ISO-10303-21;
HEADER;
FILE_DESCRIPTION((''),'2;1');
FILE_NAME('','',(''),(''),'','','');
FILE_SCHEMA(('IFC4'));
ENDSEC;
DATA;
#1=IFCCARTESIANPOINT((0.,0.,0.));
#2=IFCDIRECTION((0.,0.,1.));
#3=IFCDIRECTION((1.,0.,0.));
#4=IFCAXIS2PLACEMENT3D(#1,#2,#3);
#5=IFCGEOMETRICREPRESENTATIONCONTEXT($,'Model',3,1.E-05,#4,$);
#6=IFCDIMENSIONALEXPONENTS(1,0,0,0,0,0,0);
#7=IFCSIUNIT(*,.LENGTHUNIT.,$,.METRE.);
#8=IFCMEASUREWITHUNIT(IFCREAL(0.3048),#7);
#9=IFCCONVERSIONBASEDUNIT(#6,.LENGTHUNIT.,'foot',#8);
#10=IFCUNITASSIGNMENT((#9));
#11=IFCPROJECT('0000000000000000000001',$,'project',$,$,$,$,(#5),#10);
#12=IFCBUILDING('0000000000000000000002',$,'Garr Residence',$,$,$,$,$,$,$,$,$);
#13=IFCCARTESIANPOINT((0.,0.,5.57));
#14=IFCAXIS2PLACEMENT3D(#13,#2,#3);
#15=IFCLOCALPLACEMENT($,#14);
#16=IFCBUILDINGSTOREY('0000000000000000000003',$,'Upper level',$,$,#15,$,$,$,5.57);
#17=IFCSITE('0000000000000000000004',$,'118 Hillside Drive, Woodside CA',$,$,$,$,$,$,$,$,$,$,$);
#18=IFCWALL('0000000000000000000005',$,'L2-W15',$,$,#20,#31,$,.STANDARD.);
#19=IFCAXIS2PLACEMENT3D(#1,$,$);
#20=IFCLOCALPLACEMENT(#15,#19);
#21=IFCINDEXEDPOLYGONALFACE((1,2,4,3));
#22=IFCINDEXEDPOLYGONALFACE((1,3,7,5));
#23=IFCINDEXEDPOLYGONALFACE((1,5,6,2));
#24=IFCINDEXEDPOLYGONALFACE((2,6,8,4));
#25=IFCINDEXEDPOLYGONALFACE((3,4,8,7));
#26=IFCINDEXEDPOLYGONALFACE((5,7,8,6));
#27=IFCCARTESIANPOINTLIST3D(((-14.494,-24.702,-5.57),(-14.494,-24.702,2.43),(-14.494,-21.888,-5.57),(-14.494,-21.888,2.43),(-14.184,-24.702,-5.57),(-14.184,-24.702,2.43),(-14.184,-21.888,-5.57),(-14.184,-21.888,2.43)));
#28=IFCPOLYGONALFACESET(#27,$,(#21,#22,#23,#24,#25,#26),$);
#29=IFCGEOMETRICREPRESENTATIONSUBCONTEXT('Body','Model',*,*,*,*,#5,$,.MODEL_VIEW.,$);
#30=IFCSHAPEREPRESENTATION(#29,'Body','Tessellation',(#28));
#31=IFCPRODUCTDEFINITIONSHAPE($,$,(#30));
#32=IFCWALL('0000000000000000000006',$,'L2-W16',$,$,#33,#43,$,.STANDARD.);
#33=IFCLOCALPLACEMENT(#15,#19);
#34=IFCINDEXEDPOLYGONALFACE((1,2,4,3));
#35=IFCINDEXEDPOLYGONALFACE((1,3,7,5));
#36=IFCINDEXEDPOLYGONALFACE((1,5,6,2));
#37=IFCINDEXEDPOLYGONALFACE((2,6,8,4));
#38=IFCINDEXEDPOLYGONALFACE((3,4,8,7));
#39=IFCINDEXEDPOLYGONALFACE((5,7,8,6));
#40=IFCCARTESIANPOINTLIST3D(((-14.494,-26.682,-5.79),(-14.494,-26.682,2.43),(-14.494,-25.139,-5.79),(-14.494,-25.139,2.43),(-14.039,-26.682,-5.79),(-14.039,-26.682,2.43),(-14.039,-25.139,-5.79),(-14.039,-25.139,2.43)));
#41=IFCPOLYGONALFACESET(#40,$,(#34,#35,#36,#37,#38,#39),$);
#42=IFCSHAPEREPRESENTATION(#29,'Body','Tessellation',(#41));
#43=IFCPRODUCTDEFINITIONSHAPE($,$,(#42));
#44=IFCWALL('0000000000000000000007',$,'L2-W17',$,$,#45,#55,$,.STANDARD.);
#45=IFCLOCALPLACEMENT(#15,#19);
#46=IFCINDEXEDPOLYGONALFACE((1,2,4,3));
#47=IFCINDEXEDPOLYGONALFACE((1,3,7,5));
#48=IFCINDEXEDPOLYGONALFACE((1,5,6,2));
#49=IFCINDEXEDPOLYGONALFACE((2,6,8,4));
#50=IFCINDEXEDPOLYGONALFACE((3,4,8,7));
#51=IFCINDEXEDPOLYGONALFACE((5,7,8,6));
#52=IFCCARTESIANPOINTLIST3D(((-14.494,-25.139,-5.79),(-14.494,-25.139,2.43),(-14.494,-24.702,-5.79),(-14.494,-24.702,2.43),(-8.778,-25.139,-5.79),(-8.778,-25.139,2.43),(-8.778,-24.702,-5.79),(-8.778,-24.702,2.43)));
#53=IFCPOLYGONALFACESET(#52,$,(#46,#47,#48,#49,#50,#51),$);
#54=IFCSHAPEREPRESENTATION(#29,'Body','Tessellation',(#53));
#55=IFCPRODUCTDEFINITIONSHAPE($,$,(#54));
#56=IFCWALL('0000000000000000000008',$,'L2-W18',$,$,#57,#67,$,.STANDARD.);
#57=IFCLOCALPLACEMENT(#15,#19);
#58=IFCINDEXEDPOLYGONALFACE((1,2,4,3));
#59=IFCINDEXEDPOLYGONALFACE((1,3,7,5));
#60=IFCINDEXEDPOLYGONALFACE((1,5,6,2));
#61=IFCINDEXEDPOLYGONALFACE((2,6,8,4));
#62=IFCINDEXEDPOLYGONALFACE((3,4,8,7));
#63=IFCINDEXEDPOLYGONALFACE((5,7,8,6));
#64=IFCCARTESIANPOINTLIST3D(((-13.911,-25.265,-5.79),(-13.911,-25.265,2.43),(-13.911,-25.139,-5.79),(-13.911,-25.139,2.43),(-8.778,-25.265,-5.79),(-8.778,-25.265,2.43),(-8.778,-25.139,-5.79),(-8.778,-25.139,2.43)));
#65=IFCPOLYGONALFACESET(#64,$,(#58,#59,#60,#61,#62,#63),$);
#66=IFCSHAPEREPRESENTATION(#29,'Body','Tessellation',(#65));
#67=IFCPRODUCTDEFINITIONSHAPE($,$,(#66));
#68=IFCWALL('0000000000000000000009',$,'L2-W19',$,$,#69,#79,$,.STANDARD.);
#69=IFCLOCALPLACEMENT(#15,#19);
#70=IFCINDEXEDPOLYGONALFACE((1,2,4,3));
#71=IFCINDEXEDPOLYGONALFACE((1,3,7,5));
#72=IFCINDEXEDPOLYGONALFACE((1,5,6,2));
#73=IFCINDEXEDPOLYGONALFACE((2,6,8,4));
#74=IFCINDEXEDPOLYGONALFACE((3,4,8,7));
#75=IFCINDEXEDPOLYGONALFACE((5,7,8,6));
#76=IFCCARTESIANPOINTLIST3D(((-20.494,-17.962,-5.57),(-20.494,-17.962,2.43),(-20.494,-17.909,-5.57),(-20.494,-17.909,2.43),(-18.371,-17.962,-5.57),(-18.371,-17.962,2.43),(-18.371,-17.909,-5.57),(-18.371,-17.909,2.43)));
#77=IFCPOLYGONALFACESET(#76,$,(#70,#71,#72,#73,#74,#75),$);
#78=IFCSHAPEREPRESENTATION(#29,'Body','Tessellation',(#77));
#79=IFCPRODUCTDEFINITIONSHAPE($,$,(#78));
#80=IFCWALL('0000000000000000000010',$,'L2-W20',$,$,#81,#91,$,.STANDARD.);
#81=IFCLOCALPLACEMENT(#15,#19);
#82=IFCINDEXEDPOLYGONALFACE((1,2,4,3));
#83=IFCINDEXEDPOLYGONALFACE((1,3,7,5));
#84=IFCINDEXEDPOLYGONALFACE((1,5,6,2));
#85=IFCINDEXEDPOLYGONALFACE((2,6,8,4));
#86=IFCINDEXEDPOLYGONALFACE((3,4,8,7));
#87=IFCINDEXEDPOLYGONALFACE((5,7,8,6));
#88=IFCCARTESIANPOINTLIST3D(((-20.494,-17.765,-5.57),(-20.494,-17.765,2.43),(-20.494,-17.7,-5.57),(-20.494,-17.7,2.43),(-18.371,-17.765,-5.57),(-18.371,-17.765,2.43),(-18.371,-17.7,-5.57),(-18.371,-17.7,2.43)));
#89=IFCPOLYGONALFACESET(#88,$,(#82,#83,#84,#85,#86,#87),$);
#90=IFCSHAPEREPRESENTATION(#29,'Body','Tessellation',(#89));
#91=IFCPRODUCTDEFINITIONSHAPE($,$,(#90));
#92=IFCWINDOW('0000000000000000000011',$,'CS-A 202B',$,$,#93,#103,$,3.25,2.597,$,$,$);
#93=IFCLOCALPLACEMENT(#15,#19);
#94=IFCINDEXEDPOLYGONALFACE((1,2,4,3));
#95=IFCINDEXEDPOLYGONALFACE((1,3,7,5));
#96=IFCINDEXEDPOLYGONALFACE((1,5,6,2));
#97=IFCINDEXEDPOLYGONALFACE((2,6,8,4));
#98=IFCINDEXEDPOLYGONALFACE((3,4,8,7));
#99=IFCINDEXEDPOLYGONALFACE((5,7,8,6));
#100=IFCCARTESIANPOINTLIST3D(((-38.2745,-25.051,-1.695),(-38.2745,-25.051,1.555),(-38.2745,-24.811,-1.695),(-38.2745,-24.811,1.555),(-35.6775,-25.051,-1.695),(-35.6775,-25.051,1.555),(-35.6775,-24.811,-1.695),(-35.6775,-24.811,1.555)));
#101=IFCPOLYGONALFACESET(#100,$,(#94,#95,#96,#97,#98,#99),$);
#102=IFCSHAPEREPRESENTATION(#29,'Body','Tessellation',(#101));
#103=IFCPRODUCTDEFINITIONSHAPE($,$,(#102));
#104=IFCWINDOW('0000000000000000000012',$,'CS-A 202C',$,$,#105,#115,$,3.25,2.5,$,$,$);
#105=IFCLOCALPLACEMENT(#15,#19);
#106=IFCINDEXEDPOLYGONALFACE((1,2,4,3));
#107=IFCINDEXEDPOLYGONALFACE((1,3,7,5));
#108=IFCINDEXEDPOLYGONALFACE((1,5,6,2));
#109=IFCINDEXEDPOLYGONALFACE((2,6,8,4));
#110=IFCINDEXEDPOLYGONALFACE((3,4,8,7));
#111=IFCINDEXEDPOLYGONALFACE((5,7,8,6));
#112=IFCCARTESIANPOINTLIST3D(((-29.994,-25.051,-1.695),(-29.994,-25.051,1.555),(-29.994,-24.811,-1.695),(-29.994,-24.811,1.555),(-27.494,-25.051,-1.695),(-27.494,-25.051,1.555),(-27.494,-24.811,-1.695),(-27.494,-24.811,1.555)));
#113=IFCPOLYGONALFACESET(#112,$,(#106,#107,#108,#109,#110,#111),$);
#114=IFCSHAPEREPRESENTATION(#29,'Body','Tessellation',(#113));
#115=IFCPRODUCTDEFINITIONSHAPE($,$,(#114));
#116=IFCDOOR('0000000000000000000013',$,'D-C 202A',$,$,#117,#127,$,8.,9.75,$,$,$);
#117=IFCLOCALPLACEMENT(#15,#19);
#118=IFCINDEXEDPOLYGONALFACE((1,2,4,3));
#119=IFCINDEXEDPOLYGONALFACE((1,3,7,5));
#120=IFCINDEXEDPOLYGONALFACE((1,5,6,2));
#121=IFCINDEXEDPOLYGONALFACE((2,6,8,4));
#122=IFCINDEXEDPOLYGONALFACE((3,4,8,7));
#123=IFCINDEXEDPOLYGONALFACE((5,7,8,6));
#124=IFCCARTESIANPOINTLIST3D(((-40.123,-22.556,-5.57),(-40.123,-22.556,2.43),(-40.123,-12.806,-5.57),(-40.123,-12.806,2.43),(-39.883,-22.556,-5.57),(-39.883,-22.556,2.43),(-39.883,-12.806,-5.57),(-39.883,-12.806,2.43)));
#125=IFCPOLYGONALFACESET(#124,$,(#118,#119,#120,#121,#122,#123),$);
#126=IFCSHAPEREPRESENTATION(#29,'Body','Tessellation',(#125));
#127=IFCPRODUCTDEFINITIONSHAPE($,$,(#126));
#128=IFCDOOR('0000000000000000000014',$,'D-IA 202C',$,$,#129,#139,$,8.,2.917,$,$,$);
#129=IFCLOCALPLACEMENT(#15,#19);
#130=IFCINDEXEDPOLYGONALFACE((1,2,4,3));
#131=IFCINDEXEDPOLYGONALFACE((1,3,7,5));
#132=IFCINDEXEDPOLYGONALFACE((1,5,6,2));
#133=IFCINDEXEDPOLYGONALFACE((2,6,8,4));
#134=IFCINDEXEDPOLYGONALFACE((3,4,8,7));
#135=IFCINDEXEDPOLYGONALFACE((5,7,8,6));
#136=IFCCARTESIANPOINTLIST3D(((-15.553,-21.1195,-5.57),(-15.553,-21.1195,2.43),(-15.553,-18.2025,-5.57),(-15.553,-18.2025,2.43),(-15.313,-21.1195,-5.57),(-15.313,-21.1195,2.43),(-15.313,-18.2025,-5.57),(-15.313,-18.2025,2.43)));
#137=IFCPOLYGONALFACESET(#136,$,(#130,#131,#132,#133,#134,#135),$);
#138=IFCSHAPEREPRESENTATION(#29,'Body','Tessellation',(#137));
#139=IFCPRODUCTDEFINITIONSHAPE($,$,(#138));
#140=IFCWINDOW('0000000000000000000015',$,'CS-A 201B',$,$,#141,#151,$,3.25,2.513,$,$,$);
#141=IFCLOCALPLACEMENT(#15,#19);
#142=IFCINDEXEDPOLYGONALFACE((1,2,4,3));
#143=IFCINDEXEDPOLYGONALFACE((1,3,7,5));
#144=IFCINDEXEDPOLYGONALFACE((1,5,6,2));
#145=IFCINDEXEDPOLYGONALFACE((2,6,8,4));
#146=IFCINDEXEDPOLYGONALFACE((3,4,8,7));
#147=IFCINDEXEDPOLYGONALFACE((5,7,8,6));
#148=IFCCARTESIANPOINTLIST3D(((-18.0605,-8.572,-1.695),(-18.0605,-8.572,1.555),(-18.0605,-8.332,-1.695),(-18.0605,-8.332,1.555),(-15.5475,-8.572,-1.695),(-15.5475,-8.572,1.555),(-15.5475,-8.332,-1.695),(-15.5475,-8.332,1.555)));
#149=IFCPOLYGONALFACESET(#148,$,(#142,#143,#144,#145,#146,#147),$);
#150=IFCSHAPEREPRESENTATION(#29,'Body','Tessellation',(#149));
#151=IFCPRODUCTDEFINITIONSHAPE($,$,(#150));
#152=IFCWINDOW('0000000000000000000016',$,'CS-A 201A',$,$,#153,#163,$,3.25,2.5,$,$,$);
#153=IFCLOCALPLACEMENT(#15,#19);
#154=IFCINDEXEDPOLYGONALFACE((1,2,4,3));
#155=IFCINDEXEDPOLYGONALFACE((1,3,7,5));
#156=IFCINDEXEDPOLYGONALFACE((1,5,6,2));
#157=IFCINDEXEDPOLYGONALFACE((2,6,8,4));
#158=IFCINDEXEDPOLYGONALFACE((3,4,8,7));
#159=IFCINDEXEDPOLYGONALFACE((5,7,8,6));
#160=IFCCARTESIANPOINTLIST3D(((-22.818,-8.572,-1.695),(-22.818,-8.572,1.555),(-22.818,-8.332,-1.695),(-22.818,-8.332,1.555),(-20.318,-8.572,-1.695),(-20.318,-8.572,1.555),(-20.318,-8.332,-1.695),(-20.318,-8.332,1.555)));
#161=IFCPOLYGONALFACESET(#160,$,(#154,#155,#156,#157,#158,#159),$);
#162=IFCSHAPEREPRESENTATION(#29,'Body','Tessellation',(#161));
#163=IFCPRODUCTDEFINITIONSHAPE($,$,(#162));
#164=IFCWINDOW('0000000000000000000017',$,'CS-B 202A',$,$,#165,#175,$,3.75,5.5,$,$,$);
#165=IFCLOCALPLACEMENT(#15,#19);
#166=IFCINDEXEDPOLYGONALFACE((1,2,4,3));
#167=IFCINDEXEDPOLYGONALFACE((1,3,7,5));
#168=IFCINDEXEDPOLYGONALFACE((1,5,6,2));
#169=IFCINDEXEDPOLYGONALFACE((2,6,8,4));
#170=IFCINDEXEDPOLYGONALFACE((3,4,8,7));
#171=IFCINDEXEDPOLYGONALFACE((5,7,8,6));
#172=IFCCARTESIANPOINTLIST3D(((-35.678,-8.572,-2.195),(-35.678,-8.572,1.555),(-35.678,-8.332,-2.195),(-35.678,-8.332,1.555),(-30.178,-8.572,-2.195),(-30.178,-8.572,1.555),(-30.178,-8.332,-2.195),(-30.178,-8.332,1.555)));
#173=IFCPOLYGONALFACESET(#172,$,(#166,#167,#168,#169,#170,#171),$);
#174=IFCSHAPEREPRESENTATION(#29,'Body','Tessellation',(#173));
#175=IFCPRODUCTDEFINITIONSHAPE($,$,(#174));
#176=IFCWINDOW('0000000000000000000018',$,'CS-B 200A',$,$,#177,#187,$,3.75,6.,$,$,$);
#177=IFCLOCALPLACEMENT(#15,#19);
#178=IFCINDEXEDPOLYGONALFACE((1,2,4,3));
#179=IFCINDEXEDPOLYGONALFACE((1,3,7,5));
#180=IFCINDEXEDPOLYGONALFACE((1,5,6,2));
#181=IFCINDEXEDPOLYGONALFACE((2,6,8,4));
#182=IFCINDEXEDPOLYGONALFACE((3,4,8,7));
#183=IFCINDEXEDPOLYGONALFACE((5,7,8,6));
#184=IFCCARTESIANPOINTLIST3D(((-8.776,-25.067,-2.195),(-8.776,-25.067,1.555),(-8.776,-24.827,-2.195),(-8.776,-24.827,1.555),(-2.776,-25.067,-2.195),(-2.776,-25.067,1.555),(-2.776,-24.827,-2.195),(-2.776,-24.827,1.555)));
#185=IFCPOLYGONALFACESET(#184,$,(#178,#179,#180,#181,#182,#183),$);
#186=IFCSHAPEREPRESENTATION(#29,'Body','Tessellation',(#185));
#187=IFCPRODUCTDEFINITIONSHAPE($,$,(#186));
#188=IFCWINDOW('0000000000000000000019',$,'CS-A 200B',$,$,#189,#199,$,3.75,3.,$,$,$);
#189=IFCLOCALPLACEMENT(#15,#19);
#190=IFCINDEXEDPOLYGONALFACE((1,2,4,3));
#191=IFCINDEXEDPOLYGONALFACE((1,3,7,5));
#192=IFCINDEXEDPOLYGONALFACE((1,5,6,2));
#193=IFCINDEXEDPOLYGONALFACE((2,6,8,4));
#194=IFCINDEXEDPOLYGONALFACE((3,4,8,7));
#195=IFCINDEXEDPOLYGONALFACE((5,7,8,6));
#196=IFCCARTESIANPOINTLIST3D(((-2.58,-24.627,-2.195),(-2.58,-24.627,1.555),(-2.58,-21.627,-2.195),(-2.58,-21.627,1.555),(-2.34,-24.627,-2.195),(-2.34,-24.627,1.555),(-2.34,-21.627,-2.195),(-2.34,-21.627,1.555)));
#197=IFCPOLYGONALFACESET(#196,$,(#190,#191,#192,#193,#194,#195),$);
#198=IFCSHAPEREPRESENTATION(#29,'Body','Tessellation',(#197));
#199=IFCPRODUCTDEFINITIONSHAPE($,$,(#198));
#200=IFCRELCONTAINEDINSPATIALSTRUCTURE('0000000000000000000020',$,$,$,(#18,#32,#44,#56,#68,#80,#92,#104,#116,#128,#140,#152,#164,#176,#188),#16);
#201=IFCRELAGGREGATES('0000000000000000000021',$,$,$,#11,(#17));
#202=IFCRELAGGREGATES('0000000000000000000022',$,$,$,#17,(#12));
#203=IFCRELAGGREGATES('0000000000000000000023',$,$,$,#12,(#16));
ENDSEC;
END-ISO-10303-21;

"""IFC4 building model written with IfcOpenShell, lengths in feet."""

from ifc_helpers import new_model, entity, si_unit, converted_unit, frame, origin, origin_with_axes, place, context, subcontext, project, spatial, polyline, outline, extrude, element, save


model = new_model("IFC4")

# Units and contexts
model_context = context("Model", 3, precision=1e-05, world=origin_with_axes())
body_context = subcontext(model_context, "Body", "Model", "MODEL_VIEW")
ifc_project = project(units=[converted_unit("LENGTHUNIT", "foot", entity("IfcReal", 0.3048), si_unit("LENGTHUNIT", "METRE"), dimensions=[1, 0, 0, 0, 0, 0, 0])], contexts=[model_context])

# Site, building, storey
site = spatial("IfcSite", under=ifc_project, Name="118 Hillside Drive, Woodside CA")
building = spatial("IfcBuilding", under=site, Name="Garr Residence")
storey_placement = place(None, frame((0.0, 0.0, 5.57), z_axis=(0.0, 0.0, 1.0), x_axis=(1.0, 0.0, 0.0)))
storey = spatial("IfcBuildingStorey", under=building, at=storey_placement, Name="Upper level", Elevation=5.57)

# Walls
wall_1_placement = place(storey_placement, frame((0.0, 0.0, -5.57), z_axis=(0.0, 0.0, 1.0), x_axis=(1.0, 0.0, 0.0)))
element("IfcWall", 1, at=wall_1_placement, inside=storey, Name="L2-W15", PredefinedType="STANDARD", context=body_context, shape_type="SweptSolid", body=[
    extrude(outline(polyline([(-14.184, -24.702), (-14.184, -21.888), (-14.494, -21.888), (-14.494, -24.702), (-14.184, -24.702)])), origin(), (0.0, 0.0, 1.0), 8.0),
])
wall_2_placement = place(storey_placement, frame((0.0, 0.0, -5.79), z_axis=(0.0, 0.0, 1.0), x_axis=(1.0, 0.0, 0.0)))
element("IfcWall", 2, at=wall_2_placement, inside=storey, Name="L2-W16", PredefinedType="STANDARD", context=body_context, shape_type="SweptSolid", body=[
    extrude(outline(polyline([(-14.039, -26.682), (-14.039, -25.139), (-14.494, -25.139), (-14.494, -26.682), (-14.039, -26.682)])), origin(), (0.0, 0.0, 1.0), 8.22),
])
wall_3_placement = place(storey_placement, frame((0.0, 0.0, -5.79), z_axis=(0.0, 0.0, 1.0), x_axis=(1.0, 0.0, 0.0)))
element("IfcWall", 3, at=wall_3_placement, inside=storey, Name="L2-W17", PredefinedType="STANDARD", context=body_context, shape_type="SweptSolid", body=[
    extrude(outline(polyline([(-8.778, -25.139), (-8.778, -24.702), (-14.494, -24.702), (-14.494, -25.139), (-8.778, -25.139)])), origin(), (0.0, 0.0, 1.0), 8.22),
])
wall_4_placement = place(storey_placement, frame((0.0, 0.0, -5.79), z_axis=(0.0, 0.0, 1.0), x_axis=(1.0, 0.0, 0.0)))
element("IfcWall", 4, at=wall_4_placement, inside=storey, Name="L2-W18", PredefinedType="STANDARD", context=body_context, shape_type="SweptSolid", body=[
    extrude(outline(polyline([(-8.778, -25.265), (-8.778, -25.139), (-13.911, -25.139), (-13.911, -25.265), (-8.778, -25.265)])), origin(), (0.0, 0.0, 1.0), 8.22),
])
wall_5_placement = place(storey_placement, frame((0.0, 0.0, -5.57), z_axis=(0.0, 0.0, 1.0), x_axis=(1.0, 0.0, 0.0)))
element("IfcWall", 5, at=wall_5_placement, inside=storey, Name="L2-W19", PredefinedType="STANDARD", context=body_context, shape_type="SweptSolid", body=[
    extrude(outline(polyline([(-18.371, -17.962), (-18.371, -17.909), (-20.494, -17.909), (-20.494, -17.962), (-18.371, -17.962)])), origin(), (0.0, 0.0, 1.0), 8.0),
])
wall_6_placement = place(storey_placement, frame((0.0, 0.0, -5.57), z_axis=(0.0, 0.0, 1.0), x_axis=(1.0, 0.0, 0.0)))
element("IfcWall", 6, at=wall_6_placement, inside=storey, Name="L2-W20", PredefinedType="STANDARD", context=body_context, shape_type="SweptSolid", body=[
    extrude(outline(polyline([(-18.371, -17.765), (-18.371, -17.7), (-20.494, -17.7), (-20.494, -17.765), (-18.371, -17.765)])), origin(), (0.0, 0.0, 1.0), 8.0),
])

# Windows
window_1_placement = place(storey_placement, frame((-36.976, -24.931, -1.695), z_axis=(0.0, 0.0, 1.0), x_axis=(1.0, 0.0, 0.0)))
element("IfcWindow", 7, at=window_1_placement, inside=storey, Name="CS-A 202B", OverallHeight=3.25, OverallWidth=2.597, context=body_context, shape_type="SweptSolid", body=[
    extrude(outline(polyline([(-1.2985, -0.12), (1.2985, -0.12), (1.2985, 0.12), (-1.2985, 0.12), (-1.2985, -0.12)])), origin(), (0.0, 0.0, 1.0), 3.25),
])
window_2_placement = place(storey_placement, frame((-28.744, -24.931, -1.695), z_axis=(0.0, 0.0, 1.0), x_axis=(1.0, 0.0, 0.0)))
element("IfcWindow", 8, at=window_2_placement, inside=storey, Name="CS-A 202C", OverallHeight=3.25, OverallWidth=2.5, context=body_context, shape_type="SweptSolid", body=[
    extrude(outline(polyline([(-1.25, -0.12), (1.25, -0.12), (1.25, 0.12), (-1.25, 0.12), (-1.25, -0.12)])), origin(), (0.0, 0.0, 1.0), 3.25),
])

# Doors
door_1_placement = place(storey_placement, frame((-40.003, -17.681, -5.57), z_axis=(0.0, 0.0, 1.0), x_axis=(0.0, 1.0, 0.0)))
element("IfcDoor", 9, at=door_1_placement, inside=storey, Name="D-C 202A", OverallHeight=8.0, OverallWidth=9.75, context=body_context, shape_type="SweptSolid", body=[
    extrude(outline(polyline([(-4.875, -0.12), (4.875, -0.12), (4.875, 0.12), (-4.875, 0.12), (-4.875, -0.12)])), origin(), (0.0, 0.0, 1.0), 8.0),
])
door_2_placement = place(storey_placement, frame((-15.433, -19.661, -5.57), z_axis=(0.0, 0.0, 1.0), x_axis=(0.0, 1.0, 0.0)))
element("IfcDoor", 10, at=door_2_placement, inside=storey, Name="D-IA 202C", OverallHeight=8.0, OverallWidth=2.917, context=body_context, shape_type="SweptSolid", body=[
    extrude(outline(polyline([(-1.4585, -0.12), (1.4585, -0.12), (1.4585, 0.12), (-1.4585, 0.12), (-1.4585, -0.12)])), origin(), (0.0, 0.0, 1.0), 8.0),
])

# Windows
window_3_placement = place(storey_placement, frame((-16.804, -8.452, -1.695), z_axis=(0.0, 0.0, 1.0), x_axis=(1.0, 0.0, 0.0)))
element("IfcWindow", 11, at=window_3_placement, inside=storey, Name="CS-A 201B", OverallHeight=3.25, OverallWidth=2.513, context=body_context, shape_type="SweptSolid", body=[
    extrude(outline(polyline([(-1.2565, -0.12), (1.2565, -0.12), (1.2565, 0.12), (-1.2565, 0.12), (-1.2565, -0.12)])), origin(), (0.0, 0.0, 1.0), 3.25),
])
window_4_placement = place(storey_placement, frame((-21.568, -8.452, -1.695), z_axis=(0.0, 0.0, 1.0), x_axis=(1.0, 0.0, 0.0)))
element("IfcWindow", 12, at=window_4_placement, inside=storey, Name="CS-A 201A", OverallHeight=3.25, OverallWidth=2.5, context=body_context, shape_type="SweptSolid", body=[
    extrude(outline(polyline([(-1.25, -0.12), (1.25, -0.12), (1.25, 0.12), (-1.25, 0.12), (-1.25, -0.12)])), origin(), (0.0, 0.0, 1.0), 3.25),
])
window_5_placement = place(storey_placement, frame((-32.928, -8.452, -2.195), z_axis=(0.0, 0.0, 1.0), x_axis=(1.0, 0.0, 0.0)))
element("IfcWindow", 13, at=window_5_placement, inside=storey, Name="CS-B 202A", OverallHeight=3.75, OverallWidth=5.5, context=body_context, shape_type="SweptSolid", body=[
    extrude(outline(polyline([(-2.75, -0.12), (2.75, -0.12), (2.75, 0.12), (-2.75, 0.12), (-2.75, -0.12)])), origin(), (0.0, 0.0, 1.0), 3.75),
])
window_6_placement = place(storey_placement, frame((-5.776, -24.947, -2.195), z_axis=(0.0, 0.0, 1.0), x_axis=(1.0, 0.0, 0.0)))
element("IfcWindow", 14, at=window_6_placement, inside=storey, Name="CS-B 200A", OverallHeight=3.75, OverallWidth=6.0, context=body_context, shape_type="SweptSolid", body=[
    extrude(outline(polyline([(-3.0, -0.12), (3.0, -0.12), (3.0, 0.12), (-3.0, 0.12), (-3.0, -0.12)])), origin(), (0.0, 0.0, 1.0), 3.75),
])
window_7_placement = place(storey_placement, frame((-2.46, -23.127, -2.195), z_axis=(0.0, 0.0, 1.0), x_axis=(0.0, 1.0, 0.0)))
element("IfcWindow", 15, at=window_7_placement, inside=storey, Name="CS-A 200B", OverallHeight=3.75, OverallWidth=3.0, context=body_context, shape_type="SweptSolid", body=[
    extrude(outline(polyline([(-1.5, -0.12), (1.5, -0.12), (1.5, 0.12), (-1.5, 0.12), (-1.5, -0.12)])), origin(), (0.0, 0.0, 1.0), 3.75),
])

save(model, "model.ifc")
